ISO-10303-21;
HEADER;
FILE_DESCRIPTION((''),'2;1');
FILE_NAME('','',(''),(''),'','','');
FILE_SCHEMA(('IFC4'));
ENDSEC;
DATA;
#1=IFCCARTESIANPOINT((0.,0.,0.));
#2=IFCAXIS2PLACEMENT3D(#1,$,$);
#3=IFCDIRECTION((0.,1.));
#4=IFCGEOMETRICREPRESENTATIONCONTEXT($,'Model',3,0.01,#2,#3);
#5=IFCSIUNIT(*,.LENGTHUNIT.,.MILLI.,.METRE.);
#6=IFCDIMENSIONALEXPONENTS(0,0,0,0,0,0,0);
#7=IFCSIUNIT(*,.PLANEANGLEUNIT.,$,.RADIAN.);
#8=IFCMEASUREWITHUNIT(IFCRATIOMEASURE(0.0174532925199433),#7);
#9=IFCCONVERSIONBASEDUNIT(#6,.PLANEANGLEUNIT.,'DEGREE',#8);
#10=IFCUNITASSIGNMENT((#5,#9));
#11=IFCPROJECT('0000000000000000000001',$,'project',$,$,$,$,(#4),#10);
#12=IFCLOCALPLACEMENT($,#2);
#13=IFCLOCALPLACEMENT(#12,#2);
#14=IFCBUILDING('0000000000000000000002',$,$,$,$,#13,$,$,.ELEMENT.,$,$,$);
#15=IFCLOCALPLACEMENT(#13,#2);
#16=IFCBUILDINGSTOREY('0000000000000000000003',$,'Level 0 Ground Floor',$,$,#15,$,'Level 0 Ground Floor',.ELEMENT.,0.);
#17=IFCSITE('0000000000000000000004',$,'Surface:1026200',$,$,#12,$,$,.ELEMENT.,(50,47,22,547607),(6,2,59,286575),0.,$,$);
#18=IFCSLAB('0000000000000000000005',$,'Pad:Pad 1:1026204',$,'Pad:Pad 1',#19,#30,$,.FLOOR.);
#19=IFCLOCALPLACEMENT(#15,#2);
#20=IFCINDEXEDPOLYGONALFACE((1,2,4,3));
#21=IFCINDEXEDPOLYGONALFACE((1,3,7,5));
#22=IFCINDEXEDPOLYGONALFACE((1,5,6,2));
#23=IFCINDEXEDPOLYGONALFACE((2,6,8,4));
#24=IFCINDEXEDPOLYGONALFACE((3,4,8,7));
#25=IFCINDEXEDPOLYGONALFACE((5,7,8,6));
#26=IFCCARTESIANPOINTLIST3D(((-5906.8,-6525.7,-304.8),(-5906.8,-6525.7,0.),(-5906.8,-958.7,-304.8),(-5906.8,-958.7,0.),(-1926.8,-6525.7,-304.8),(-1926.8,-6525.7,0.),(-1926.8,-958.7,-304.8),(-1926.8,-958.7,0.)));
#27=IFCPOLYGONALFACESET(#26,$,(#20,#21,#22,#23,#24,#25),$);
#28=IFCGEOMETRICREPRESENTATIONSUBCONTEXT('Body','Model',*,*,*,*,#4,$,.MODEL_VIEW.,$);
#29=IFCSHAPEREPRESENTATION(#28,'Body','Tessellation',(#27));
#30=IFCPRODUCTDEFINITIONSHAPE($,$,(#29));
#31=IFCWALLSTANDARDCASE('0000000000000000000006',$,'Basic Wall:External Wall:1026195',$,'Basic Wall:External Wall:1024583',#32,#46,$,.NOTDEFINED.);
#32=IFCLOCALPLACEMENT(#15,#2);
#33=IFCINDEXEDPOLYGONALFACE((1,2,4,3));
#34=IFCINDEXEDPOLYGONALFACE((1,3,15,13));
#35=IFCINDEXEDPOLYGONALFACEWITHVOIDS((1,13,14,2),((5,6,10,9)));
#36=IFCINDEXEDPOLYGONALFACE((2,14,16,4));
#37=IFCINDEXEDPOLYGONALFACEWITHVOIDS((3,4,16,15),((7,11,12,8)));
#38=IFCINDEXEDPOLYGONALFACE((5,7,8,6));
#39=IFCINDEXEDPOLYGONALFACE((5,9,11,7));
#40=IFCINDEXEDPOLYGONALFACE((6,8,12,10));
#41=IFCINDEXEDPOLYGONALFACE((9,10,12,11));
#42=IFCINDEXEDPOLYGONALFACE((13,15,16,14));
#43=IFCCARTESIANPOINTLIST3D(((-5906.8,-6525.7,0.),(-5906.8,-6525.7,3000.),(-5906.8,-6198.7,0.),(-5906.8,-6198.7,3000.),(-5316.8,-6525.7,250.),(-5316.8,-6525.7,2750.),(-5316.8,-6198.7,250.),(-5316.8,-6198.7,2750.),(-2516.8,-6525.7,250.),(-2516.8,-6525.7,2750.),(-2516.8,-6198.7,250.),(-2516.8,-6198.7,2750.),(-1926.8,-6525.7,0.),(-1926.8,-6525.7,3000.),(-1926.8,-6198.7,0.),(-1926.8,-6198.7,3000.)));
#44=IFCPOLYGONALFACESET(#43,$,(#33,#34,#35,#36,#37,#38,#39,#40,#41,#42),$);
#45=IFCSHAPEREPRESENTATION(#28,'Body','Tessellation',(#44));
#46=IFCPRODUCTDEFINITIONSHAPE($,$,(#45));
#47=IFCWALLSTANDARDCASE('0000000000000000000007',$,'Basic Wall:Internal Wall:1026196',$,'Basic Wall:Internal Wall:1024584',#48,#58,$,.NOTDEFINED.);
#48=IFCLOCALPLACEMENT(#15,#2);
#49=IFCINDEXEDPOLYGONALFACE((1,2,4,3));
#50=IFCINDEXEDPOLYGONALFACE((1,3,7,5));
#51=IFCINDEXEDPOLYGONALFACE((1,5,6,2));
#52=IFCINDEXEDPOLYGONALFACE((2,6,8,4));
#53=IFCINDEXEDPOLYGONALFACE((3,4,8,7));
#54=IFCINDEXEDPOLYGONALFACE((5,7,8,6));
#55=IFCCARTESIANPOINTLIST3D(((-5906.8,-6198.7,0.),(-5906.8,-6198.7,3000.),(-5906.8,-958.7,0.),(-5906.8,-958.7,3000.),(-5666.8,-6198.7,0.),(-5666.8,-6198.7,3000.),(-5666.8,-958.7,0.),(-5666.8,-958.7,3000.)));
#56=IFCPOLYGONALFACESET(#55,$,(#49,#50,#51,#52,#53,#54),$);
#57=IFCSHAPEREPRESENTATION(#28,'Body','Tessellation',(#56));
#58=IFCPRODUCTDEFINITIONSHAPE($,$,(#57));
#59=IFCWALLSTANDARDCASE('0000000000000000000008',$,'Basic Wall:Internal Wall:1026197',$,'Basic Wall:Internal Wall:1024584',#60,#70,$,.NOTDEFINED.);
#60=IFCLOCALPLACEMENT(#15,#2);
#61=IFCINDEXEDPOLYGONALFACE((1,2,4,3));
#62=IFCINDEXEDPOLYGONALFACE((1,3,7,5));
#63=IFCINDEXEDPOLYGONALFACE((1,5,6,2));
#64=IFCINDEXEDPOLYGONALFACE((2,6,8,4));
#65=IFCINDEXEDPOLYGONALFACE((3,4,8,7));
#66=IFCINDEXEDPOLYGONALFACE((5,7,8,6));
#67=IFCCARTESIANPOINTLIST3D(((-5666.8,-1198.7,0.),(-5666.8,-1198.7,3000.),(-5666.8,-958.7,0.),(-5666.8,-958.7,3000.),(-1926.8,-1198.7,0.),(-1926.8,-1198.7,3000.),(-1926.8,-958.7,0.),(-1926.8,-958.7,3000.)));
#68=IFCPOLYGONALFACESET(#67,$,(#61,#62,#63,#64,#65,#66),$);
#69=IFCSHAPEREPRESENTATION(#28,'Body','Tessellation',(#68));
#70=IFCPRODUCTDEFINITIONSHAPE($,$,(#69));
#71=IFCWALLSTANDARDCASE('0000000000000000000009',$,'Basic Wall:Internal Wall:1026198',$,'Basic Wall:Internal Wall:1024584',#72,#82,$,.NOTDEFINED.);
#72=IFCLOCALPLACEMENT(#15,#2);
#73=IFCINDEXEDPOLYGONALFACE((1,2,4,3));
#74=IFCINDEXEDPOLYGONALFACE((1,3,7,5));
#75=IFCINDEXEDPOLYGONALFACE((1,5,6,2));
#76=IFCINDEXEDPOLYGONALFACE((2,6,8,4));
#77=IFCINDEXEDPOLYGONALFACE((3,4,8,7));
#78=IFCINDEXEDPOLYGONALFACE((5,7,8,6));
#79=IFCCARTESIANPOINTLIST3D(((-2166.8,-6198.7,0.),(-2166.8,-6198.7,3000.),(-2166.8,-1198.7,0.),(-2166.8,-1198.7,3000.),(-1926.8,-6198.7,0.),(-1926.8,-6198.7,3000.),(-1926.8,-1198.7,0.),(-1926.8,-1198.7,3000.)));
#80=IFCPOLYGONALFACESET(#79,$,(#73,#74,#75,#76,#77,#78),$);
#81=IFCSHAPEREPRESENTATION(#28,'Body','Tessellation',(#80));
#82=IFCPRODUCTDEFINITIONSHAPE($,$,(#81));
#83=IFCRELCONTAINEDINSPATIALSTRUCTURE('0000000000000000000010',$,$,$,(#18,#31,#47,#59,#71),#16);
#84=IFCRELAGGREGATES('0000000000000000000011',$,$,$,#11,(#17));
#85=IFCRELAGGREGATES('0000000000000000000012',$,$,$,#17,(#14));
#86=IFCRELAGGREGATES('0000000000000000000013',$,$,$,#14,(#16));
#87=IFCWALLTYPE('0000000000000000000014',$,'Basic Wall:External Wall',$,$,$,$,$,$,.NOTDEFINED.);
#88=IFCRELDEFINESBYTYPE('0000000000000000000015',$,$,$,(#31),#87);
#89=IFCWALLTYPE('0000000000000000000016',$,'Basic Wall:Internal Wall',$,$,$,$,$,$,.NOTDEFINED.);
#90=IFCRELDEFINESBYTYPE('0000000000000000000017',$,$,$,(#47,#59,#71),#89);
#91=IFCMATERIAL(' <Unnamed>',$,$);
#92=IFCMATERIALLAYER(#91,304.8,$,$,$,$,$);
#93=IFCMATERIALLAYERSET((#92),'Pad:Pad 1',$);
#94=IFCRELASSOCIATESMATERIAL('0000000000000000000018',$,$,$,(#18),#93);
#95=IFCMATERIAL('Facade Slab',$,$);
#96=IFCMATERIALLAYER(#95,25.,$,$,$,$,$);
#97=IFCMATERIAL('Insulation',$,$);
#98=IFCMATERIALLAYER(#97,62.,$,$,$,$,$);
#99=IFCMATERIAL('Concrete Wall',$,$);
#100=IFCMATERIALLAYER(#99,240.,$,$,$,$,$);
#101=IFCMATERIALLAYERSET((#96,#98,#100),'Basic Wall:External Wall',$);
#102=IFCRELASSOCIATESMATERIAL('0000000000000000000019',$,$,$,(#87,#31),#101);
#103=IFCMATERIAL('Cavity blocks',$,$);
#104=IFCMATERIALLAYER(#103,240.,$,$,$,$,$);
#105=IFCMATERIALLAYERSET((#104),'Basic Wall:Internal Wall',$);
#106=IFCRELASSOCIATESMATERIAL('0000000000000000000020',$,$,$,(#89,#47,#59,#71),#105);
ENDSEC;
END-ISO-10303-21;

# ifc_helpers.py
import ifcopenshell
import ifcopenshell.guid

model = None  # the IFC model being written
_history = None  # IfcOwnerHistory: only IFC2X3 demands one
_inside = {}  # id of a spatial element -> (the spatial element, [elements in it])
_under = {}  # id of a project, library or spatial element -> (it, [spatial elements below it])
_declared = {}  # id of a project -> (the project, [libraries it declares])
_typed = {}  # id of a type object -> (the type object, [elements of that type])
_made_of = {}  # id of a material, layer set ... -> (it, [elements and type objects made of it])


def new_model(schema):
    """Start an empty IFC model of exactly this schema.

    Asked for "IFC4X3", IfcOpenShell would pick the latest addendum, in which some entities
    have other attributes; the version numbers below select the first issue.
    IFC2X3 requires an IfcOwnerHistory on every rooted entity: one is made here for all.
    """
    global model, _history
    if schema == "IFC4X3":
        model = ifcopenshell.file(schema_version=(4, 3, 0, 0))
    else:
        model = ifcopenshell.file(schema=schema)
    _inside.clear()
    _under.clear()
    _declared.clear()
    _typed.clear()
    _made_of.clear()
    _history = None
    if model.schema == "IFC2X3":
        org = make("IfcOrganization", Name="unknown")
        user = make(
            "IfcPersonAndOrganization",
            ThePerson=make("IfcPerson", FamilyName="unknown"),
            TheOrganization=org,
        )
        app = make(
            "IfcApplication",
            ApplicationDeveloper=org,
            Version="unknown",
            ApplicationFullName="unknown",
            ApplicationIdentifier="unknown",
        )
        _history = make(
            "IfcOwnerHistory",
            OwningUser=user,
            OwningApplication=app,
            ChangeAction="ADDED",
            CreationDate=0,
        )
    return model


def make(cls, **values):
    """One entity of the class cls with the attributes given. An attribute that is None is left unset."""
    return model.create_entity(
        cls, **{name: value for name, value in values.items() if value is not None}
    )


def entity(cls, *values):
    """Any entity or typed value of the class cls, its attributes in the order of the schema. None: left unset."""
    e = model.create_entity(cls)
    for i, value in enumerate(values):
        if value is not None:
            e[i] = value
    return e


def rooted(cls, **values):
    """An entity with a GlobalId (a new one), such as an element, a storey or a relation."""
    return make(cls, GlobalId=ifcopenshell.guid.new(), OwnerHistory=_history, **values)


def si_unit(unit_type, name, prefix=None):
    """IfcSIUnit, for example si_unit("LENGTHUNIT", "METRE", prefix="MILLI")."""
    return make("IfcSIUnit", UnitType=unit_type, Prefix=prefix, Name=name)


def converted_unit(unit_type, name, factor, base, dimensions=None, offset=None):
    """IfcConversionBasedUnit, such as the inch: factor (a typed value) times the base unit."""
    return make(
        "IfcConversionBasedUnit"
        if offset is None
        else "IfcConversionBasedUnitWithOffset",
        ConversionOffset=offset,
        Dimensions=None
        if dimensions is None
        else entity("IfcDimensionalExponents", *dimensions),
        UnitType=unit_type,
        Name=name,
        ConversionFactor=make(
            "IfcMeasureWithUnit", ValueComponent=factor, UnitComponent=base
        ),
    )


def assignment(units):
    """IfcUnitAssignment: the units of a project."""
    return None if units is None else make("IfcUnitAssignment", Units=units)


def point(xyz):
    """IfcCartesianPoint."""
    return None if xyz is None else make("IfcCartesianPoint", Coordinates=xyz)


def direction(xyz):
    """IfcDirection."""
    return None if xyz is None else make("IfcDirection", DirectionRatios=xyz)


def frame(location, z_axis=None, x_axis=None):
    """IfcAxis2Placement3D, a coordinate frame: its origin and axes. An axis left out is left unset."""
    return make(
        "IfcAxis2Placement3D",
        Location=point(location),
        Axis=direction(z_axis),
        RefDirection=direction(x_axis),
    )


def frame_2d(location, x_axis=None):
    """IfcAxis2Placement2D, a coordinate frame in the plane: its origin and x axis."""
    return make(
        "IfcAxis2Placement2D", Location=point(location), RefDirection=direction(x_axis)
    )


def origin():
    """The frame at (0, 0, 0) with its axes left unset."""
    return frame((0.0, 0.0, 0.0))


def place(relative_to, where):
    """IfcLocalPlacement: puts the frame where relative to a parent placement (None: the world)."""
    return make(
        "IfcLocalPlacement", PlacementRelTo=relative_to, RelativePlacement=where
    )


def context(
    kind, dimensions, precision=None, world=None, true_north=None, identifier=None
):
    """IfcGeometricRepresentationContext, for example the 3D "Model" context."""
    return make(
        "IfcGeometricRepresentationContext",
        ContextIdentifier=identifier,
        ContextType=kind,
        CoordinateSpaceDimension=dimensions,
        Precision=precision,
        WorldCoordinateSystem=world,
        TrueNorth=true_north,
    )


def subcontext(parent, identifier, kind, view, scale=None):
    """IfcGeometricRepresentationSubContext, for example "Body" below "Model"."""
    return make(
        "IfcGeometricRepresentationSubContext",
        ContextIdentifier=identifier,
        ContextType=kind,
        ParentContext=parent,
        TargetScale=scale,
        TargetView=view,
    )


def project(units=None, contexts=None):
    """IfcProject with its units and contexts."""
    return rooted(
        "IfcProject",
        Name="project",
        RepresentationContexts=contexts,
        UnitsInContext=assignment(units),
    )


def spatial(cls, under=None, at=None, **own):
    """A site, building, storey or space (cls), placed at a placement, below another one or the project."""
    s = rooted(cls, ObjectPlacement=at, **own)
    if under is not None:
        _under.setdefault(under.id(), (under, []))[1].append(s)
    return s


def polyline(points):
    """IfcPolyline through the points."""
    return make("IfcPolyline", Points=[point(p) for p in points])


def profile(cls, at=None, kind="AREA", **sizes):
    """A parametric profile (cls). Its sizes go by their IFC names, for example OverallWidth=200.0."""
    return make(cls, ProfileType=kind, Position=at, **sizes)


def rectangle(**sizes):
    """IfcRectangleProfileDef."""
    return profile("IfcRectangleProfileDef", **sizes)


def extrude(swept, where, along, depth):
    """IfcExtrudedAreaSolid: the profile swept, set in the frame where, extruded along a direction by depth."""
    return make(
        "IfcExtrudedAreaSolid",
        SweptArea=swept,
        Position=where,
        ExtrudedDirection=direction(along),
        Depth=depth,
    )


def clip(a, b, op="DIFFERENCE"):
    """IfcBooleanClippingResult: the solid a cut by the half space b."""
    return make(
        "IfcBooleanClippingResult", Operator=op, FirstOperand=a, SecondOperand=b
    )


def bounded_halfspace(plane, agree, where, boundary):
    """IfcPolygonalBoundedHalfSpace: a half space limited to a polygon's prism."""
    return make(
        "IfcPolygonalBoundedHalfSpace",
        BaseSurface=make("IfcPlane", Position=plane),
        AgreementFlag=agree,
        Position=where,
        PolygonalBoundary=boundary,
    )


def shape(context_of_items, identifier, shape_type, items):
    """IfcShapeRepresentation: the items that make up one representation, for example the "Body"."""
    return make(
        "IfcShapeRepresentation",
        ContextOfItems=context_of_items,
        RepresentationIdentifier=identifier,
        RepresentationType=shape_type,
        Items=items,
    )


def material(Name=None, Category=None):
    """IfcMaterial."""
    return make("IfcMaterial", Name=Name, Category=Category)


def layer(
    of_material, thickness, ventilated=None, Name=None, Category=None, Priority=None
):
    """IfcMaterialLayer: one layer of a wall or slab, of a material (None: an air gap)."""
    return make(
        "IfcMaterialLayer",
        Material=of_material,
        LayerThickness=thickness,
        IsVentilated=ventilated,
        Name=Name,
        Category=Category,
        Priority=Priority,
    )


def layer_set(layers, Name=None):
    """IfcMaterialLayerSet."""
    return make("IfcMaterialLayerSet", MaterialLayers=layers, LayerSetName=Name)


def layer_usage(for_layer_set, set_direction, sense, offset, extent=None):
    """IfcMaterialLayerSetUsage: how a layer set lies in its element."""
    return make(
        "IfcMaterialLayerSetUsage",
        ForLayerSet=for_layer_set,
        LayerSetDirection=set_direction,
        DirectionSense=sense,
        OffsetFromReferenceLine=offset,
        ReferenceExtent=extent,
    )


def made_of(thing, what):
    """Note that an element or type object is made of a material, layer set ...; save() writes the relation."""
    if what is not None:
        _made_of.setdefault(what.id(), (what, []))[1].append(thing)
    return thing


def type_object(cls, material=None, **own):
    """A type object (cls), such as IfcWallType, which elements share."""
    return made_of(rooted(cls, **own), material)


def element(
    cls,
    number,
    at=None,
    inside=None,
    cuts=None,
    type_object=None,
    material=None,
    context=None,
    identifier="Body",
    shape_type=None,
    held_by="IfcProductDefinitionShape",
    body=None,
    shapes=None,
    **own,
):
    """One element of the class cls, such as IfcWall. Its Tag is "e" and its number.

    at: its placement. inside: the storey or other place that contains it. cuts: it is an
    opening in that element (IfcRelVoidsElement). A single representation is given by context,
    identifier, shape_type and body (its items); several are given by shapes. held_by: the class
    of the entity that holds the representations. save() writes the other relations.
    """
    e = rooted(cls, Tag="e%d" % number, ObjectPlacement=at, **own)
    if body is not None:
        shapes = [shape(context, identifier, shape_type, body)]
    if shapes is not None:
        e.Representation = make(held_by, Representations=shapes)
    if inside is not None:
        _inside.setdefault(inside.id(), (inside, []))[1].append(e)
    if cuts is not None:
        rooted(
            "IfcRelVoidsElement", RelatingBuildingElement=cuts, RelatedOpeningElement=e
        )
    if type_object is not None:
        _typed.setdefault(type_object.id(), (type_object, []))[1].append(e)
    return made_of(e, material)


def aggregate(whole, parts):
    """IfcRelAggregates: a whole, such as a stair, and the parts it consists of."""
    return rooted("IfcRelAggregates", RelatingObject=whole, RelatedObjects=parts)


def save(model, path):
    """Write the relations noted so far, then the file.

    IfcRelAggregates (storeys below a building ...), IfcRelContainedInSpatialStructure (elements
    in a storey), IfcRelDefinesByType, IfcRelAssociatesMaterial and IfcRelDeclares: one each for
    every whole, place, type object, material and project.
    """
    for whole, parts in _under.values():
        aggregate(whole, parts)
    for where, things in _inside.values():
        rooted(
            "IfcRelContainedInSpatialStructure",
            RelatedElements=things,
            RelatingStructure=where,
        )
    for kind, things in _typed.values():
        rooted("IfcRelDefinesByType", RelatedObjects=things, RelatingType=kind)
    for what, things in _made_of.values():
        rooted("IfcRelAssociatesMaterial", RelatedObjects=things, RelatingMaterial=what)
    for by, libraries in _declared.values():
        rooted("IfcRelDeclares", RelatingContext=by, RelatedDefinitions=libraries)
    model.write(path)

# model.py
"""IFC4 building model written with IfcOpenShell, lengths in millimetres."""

from ifc_helpers import new_model, entity, si_unit, converted_unit, direction, frame, frame_2d, origin, place, context, subcontext, project, spatial, polyline, rectangle, extrude, clip, bounded_halfspace, material, layer, layer_set, layer_usage, type_object, element, save


model = new_model("IFC4")

# Units and contexts
model_context = context("Model", 3, precision=0.01, world=origin(), true_north=direction((0.0, 1.0)))
body_context = subcontext(model_context, "Body", "Model", "MODEL_VIEW")
ifc_project = project(units=[si_unit("LENGTHUNIT", "METRE", prefix="MILLI"), converted_unit("PLANEANGLEUNIT", "DEGREE", entity("IfcRatioMeasure", 0.0174532925199433), si_unit("PLANEANGLEUNIT", "RADIAN"), dimensions=[0, 0, 0, 0, 0, 0, 0])], contexts=[model_context])

# Site, building, storey
site_placement = place(None, origin())
site = spatial("IfcSite", under=ifc_project, at=site_placement, Name="Surface:1026200", CompositionType="ELEMENT", RefLatitude=(50, 47, 22, 547607), RefLongitude=(6, 2, 59, 286575), RefElevation=0.0)
building_placement = place(site_placement, origin())
building = spatial("IfcBuilding", under=site, at=building_placement, CompositionType="ELEMENT")
storey_placement = place(building_placement, origin())
storey = spatial("IfcBuildingStorey", under=building, at=storey_placement, Name="Level 0 Ground Floor", LongName="Level 0 Ground Floor", CompositionType="ELEMENT", Elevation=0.0)

# Slab
ifc_material_1 = material(Name=" <Unnamed>")
ifc_layer_1 = layer(ifc_material_1, 304.8)
ifc_layer_set_1 = layer_set([ifc_layer_1], Name="Pad:Pad 1")
ifc_layer_usage_1 = layer_usage(ifc_layer_set_1, "AXIS3", "NEGATIVE", 0.0)
slab_placement = place(storey_placement, frame((-5906.8, -6525.7, -304.8)))
element("IfcSlab", 1, at=slab_placement, inside=storey, material=ifc_layer_usage_1, Name="Pad:Pad 1:1026204", ObjectType="Pad:Pad 1", PredefinedType="FLOOR", context=body_context, shape_type="SweptSolid", body=[
    extrude(rectangle(XDim=5567.0, YDim=3980.0, at=frame_2d((0.0, 0.0), x_axis=(0.0, -1.0))), frame((1990.0, 2783.5, 304.8), z_axis=(0.0, 0.0, -1.0), x_axis=(-1.0, 0.0, 0.0)), (0.0, 0.0, 1.0), 304.8),
])

# Wall, opening
ifc_material_2 = material(Name="Facade Slab")
ifc_layer_2 = layer(ifc_material_2, 25.0)
ifc_material_3 = material(Name="Insulation")
ifc_layer_3 = layer(ifc_material_3, 62.0)
ifc_material_4 = material(Name="Concrete Wall")
ifc_layer_4 = layer(ifc_material_4, 240.0)
ifc_layer_set_2 = layer_set([ifc_layer_2, ifc_layer_3, ifc_layer_4], Name="Basic Wall:External Wall")
ifc_layer_usage_2 = layer_usage(ifc_layer_set_2, "AXIS2", "POSITIVE", -163.5)
wall_type_1 = type_object("IfcWallType", Name="Basic Wall:External Wall", PredefinedType="NOTDEFINED", material=ifc_layer_set_2)
wall_1_placement = place(storey_placement, frame((-5906.8, -6362.2, 0.0)))
wall_1 = element("IfcWallStandardCase", 2, at=wall_1_placement, inside=storey, type_object=wall_type_1, material=ifc_layer_usage_2, Name="Basic Wall:External Wall:1026195", ObjectType="Basic Wall:External Wall:1024583", PredefinedType="NOTDEFINED", context=body_context, shape_type="Clipping", body=[
    clip(extrude(rectangle(XDim=3980.0, YDim=327.0, at=frame_2d((1990.0, 0.0), x_axis=(-1.0, 0.0))), origin(), (0.0, 0.0, 1.0), 3000.0), bounded_halfspace(frame((0.0, -163.5, 3000.0), z_axis=(0.0, 0.0, -1.0), x_axis=(0.0, -1.0, 0.0)), True, frame((0.0, -163.5, 3000.0)), polyline([(0.0, 0.0), (3980.0, 0.0), (3980.0, 327.0), (3740.0, 327.0), (240.0, 327.0), (0.0, 327.0), (0.0, 0.0)]))),
])
opening_placement = place(wall_1_placement, frame((590.0, -163.5, 250.0)))
element("IfcOpeningElement", 3, at=opening_placement, cuts=wall_1, ObjectType="Opening", PredefinedType="OPENING", context=body_context, shape_type="SweptSolid", body=[
    extrude(rectangle(XDim=2500.0, YDim=2800.0, at=frame_2d((1250.0, 1400.0), x_axis=(1.0, 0.0))), frame((0.0, 0.0, 0.0), z_axis=(0.0, 1.0, 0.0), x_axis=(0.0, 0.0, 1.0)), (0.0, 0.0, 1.0), 327.0),
])

# Walls
ifc_material_5 = material(Name="Cavity blocks")
ifc_layer_5 = layer(ifc_material_5, 240.0)
ifc_layer_set_3 = layer_set([ifc_layer_5], Name="Basic Wall:Internal Wall")
ifc_layer_usage_3 = layer_usage(ifc_layer_set_3, "AXIS2", "NEGATIVE", 120.0)
wall_type_2 = type_object("IfcWallType", Name="Basic Wall:Internal Wall", PredefinedType="NOTDEFINED", material=ifc_layer_set_3)
wall_2_placement = place(storey_placement, frame((-5786.8, -6198.7, 0.0), z_axis=(0.0, 0.0, 1.0), x_axis=(0.0, 1.0, 0.0)))
element("IfcWallStandardCase", 4, at=wall_2_placement, inside=storey, type_object=wall_type_2, material=ifc_layer_usage_3, Name="Basic Wall:Internal Wall:1026196", ObjectType="Basic Wall:Internal Wall:1024584", PredefinedType="NOTDEFINED", context=body_context, shape_type="Clipping", body=[
    clip(extrude(rectangle(XDim=5240.0, YDim=240.0, at=frame_2d((2620.0, 0.0), x_axis=(-1.0, 0.0))), origin(), (0.0, 0.0, 1.0), 3000.0), bounded_halfspace(frame((0.0, -120.0, 3000.0), z_axis=(0.0, 0.0, -1.0), x_axis=(-1.0, 0.0, 0.0)), True, frame((0.0, -120.0, 3000.0)), polyline([(0.0, 0.0), (5000.0, 0.0), (5240.0, 0.0), (5240.0, 240.0), (0.0, 240.0), (0.0, 0.0)]))),
])
ifc_layer_usage_4 = layer_usage(ifc_layer_set_3, "AXIS2", "NEGATIVE", 120.0)
wall_3_placement = place(storey_placement, frame((-5666.8, -1078.7, 0.0)))
element("IfcWallStandardCase", 5, at=wall_3_placement, inside=storey, type_object=wall_type_2, material=ifc_layer_usage_4, Name="Basic Wall:Internal Wall:1026197", ObjectType="Basic Wall:Internal Wall:1024584", PredefinedType="NOTDEFINED", context=body_context, shape_type="Clipping", body=[
    clip(extrude(rectangle(XDim=3740.0, YDim=240.0, at=frame_2d((1870.0, 0.0), x_axis=(-1.0, 0.0))), origin(), (0.0, 0.0, 1.0), 3000.0), bounded_halfspace(frame((0.0, -120.0, 3000.0), z_axis=(0.0, 0.0, -1.0), x_axis=(0.0, -1.0, 0.0)), True, frame((0.0, -120.0, 3000.0)), polyline([(0.0, 0.0), (3500.0, 0.0), (3740.0, 0.0), (3740.0, 240.0), (0.0, 240.0), (0.0, 0.0)]))),
])
ifc_layer_usage_5 = layer_usage(ifc_layer_set_3, "AXIS2", "NEGATIVE", 120.0)
wall_4_placement = place(storey_placement, frame((-2046.8, -1198.7, 0.0), z_axis=(0.0, 0.0, 1.0), x_axis=(0.0, -1.0, 0.0)))
element("IfcWallStandardCase", 6, at=wall_4_placement, inside=storey, type_object=wall_type_2, material=ifc_layer_usage_5, Name="Basic Wall:Internal Wall:1026198", ObjectType="Basic Wall:Internal Wall:1024584", PredefinedType="NOTDEFINED", context=body_context, shape_type="Clipping", body=[
    clip(extrude(rectangle(XDim=5000.0, YDim=240.0, at=frame_2d((2500.0, 0.0), x_axis=(-1.0, 0.0))), origin(), (0.0, 0.0, 1.0), 3000.0), bounded_halfspace(frame((0.0, -120.0, 3000.0), z_axis=(0.0, 0.0, -1.0), x_axis=(1.0, 0.0, 0.0)), True, frame((0.0, -120.0, 3000.0)), polyline([(0.0, 0.0), (5000.0, 0.0), (5000.0, 240.0), (0.0, 240.0), (0.0, 0.0)]))),
])

save(model, "model.ifc")
